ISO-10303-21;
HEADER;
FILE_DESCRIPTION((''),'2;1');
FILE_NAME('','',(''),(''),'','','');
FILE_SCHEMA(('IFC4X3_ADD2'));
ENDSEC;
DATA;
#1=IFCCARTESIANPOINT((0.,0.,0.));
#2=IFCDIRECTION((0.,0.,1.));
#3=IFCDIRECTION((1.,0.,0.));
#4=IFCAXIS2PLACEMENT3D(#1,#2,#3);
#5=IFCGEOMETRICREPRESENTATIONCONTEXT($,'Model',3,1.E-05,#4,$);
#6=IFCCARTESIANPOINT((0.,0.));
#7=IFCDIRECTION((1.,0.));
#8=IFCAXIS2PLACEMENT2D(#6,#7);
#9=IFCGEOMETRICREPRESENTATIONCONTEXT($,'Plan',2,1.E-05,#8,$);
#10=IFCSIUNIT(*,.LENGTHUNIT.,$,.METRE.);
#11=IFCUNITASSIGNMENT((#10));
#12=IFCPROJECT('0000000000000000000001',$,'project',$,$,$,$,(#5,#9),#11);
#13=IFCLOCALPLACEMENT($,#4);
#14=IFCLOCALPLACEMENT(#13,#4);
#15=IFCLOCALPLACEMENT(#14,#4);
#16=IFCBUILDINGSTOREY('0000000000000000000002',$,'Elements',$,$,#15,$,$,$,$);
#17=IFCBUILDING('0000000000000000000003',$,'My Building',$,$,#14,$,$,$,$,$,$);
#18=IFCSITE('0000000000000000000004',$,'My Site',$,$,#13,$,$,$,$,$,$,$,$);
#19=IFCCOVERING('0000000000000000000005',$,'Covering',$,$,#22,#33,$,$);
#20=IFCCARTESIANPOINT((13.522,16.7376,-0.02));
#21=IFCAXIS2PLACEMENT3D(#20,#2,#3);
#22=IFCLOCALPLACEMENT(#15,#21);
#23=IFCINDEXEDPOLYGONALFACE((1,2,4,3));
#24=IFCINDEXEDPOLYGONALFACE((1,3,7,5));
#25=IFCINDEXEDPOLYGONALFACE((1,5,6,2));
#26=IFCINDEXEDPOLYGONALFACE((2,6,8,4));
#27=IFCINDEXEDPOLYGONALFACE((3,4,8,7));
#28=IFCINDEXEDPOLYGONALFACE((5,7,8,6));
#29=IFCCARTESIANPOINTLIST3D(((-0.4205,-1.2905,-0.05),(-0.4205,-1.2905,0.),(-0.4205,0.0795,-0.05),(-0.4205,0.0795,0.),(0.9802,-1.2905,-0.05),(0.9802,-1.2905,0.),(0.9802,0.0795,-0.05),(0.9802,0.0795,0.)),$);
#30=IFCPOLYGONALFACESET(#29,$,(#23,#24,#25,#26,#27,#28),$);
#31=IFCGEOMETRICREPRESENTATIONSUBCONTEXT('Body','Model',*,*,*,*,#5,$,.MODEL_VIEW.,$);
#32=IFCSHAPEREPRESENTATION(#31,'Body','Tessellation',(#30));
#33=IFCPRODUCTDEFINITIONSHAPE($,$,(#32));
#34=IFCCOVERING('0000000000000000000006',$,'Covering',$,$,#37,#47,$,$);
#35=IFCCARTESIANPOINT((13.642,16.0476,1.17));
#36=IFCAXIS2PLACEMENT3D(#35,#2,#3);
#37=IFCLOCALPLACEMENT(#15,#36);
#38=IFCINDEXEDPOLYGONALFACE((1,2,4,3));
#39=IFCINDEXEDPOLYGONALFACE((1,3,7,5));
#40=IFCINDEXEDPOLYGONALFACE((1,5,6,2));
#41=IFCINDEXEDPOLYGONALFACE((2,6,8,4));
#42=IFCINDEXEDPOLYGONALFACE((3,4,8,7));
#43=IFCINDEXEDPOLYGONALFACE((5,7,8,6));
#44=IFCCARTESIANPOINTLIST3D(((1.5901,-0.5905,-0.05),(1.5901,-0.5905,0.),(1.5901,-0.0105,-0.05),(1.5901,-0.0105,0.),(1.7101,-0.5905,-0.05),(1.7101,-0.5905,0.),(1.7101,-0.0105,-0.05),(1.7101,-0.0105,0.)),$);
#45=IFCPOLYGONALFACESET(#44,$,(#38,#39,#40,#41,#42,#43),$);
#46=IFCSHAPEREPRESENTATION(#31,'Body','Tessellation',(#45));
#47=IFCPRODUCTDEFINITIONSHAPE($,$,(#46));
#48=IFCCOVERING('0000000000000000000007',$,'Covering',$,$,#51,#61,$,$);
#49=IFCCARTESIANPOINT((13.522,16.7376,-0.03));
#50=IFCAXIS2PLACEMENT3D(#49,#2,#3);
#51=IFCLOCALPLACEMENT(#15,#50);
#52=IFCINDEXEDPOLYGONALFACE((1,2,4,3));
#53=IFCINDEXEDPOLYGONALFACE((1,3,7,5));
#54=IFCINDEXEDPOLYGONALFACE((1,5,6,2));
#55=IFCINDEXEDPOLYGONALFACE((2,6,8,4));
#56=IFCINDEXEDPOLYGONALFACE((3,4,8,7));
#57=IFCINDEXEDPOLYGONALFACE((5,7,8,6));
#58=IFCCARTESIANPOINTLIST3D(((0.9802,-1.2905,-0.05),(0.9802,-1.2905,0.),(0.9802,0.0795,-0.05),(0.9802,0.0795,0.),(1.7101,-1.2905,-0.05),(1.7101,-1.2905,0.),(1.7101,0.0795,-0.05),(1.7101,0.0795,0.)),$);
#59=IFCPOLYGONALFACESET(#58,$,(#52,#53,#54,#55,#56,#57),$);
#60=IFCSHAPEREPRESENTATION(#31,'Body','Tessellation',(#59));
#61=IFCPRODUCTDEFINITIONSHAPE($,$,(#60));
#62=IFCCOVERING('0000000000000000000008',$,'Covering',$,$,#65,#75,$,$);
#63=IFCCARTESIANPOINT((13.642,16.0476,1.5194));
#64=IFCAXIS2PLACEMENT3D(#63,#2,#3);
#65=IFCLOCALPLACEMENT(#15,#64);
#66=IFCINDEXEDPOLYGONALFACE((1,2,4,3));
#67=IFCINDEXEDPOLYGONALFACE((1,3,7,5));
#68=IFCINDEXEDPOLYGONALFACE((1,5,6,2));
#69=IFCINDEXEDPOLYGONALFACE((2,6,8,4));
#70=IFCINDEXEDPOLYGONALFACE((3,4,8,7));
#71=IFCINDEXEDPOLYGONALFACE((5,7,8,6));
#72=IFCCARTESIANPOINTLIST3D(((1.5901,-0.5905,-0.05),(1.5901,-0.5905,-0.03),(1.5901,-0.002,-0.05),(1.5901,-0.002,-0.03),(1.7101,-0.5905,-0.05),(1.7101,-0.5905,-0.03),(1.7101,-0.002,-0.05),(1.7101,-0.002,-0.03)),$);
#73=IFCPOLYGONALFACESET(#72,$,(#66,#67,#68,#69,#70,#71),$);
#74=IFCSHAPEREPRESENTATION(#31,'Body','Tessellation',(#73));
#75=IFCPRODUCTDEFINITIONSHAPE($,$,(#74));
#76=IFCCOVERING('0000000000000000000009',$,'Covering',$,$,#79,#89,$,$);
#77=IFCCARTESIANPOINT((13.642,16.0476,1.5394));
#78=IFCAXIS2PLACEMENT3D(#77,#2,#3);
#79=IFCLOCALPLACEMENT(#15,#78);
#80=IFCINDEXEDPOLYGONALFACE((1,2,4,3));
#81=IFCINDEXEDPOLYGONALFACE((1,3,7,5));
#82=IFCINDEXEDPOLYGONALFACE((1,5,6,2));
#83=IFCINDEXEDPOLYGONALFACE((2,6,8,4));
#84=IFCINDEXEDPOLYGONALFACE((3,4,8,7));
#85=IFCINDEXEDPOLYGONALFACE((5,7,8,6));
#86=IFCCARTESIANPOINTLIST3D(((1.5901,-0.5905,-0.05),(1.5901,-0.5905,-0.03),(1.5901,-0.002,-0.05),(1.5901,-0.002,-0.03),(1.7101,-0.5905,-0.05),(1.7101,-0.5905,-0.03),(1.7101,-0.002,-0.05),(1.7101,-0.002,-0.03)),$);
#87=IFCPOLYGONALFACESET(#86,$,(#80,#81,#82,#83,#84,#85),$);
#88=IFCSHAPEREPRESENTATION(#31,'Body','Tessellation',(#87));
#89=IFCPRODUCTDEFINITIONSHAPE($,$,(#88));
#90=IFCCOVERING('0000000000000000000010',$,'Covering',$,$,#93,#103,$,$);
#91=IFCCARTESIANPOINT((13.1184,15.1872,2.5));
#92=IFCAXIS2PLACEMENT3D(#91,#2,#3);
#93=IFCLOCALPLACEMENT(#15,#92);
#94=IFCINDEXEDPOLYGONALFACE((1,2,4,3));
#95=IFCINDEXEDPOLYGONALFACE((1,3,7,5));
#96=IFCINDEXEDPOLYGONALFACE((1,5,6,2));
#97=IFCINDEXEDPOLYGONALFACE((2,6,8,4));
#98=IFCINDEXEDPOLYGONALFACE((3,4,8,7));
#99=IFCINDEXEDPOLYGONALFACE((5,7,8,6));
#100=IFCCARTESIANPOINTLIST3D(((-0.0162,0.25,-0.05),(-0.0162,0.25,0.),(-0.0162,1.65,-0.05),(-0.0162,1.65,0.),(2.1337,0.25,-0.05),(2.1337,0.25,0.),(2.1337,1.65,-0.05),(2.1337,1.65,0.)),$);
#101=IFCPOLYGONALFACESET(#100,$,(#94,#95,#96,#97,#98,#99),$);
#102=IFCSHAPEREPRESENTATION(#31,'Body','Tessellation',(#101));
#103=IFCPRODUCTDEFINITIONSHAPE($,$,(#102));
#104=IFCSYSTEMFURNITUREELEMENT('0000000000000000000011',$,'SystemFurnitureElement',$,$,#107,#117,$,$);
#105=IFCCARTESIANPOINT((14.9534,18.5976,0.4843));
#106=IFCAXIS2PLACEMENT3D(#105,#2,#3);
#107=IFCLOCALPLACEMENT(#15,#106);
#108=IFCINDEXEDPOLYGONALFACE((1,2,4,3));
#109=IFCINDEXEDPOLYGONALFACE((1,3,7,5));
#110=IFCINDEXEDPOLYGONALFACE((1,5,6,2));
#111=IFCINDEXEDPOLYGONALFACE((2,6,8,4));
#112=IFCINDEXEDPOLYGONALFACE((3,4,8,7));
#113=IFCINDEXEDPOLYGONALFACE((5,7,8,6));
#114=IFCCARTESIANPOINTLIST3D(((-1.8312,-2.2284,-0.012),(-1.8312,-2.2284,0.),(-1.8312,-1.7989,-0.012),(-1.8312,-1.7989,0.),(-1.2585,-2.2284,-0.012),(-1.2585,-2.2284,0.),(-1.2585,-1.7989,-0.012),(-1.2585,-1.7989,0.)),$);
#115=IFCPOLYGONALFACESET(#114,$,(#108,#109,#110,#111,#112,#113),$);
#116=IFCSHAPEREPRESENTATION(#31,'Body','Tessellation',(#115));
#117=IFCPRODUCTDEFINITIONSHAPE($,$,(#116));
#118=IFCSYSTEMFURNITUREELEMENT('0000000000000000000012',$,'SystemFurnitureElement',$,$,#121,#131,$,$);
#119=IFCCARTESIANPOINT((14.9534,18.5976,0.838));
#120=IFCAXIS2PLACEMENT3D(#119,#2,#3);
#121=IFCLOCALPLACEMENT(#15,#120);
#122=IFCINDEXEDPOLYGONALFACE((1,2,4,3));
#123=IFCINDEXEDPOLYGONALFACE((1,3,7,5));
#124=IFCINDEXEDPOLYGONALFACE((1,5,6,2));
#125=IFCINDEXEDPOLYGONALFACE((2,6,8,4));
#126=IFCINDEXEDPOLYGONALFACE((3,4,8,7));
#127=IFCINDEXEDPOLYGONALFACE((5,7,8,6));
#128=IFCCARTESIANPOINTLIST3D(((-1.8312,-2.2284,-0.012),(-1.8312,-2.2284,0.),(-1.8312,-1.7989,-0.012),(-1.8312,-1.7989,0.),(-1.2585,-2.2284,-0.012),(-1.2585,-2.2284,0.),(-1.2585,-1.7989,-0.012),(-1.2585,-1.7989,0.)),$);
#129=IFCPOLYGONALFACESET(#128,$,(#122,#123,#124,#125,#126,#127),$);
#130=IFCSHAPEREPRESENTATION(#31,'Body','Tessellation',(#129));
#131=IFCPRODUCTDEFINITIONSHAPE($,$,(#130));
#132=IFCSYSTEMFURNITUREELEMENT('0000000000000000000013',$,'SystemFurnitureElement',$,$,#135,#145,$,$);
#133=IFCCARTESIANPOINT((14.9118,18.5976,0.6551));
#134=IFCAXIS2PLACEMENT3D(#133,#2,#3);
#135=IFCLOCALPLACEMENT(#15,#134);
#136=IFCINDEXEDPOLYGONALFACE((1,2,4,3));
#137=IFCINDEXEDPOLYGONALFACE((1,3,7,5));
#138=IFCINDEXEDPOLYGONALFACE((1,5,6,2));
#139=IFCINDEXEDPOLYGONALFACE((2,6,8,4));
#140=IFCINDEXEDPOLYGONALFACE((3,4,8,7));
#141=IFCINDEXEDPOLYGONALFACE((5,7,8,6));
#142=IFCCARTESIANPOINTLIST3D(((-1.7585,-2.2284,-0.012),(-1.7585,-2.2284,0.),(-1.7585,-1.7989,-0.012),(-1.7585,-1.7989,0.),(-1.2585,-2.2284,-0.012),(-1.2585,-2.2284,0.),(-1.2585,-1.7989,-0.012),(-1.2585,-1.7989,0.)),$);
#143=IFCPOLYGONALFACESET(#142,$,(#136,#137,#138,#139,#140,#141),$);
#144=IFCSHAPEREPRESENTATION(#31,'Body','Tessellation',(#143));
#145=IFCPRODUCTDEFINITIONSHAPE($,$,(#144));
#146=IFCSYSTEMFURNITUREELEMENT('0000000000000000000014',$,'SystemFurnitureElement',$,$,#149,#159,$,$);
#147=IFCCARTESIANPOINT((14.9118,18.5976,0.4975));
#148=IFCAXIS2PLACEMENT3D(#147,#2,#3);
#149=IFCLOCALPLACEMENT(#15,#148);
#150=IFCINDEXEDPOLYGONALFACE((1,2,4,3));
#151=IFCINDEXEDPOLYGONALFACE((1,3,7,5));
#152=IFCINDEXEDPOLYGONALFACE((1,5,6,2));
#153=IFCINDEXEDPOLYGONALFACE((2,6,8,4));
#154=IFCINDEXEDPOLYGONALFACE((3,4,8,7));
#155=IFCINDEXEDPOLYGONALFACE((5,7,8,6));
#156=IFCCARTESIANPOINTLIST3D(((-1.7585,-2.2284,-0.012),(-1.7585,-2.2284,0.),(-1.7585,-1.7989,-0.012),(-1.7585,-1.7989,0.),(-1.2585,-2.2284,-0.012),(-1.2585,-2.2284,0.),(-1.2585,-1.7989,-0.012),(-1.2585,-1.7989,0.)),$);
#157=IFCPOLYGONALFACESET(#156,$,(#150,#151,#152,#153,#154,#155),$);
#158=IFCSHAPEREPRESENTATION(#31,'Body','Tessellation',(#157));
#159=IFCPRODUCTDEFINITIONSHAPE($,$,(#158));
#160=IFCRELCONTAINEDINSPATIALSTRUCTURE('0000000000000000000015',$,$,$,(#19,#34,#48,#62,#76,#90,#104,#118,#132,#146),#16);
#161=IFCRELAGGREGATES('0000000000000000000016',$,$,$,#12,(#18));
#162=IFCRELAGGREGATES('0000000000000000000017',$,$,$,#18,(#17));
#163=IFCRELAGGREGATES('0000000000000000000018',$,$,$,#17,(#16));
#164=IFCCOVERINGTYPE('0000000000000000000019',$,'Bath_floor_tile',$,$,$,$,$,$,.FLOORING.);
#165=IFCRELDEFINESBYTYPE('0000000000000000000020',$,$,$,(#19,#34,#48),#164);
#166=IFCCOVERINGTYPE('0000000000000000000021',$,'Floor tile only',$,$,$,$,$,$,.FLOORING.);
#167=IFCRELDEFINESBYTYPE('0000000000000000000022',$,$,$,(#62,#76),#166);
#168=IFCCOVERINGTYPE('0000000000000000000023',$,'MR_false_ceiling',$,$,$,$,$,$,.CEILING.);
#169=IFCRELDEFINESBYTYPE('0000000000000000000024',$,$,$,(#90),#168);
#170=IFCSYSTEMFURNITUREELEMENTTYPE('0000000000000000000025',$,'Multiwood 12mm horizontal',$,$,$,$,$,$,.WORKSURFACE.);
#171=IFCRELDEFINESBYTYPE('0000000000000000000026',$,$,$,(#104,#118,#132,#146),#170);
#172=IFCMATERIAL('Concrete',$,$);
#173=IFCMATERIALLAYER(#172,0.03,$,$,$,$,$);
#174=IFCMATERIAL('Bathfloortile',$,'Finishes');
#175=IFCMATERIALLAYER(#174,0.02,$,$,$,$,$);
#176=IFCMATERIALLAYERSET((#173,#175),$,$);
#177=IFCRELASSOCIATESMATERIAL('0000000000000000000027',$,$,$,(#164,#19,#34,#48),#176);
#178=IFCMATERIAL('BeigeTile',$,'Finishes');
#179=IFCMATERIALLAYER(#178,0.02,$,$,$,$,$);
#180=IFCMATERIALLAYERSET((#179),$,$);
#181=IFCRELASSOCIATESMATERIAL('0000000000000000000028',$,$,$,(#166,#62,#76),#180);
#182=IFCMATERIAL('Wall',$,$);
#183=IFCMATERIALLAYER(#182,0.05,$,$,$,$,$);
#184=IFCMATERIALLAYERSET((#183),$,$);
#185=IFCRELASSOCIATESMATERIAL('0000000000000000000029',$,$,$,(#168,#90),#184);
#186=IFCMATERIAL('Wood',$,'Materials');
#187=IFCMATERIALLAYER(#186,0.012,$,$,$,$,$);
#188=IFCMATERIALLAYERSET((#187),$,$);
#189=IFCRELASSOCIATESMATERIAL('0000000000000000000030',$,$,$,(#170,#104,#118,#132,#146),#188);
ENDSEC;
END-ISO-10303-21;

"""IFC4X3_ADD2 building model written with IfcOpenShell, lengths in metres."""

from ifc_helpers import new_model, si_unit, frame, origin_with_axes, origin_2d_with_axis, place, context, subcontext, project, spatial, indexed_curve, outline, extrude, material, layer, layer_set, layer_usage, type_object, element, save


model = new_model("IFC4X3_ADD2")

# Units and contexts
model_context = context("Model", 3, precision=1e-05, world=origin_with_axes())
plan_context = context("Plan", 2, precision=1e-05, world=origin_2d_with_axis())
body_context = subcontext(model_context, "Body", "Model", "MODEL_VIEW")
ifc_project = project(units=[si_unit("LENGTHUNIT", "METRE")], contexts=[model_context, plan_context])

# Site, building, storey
site_placement = place(None, origin_with_axes())
site = spatial("IfcSite", under=ifc_project, at=site_placement, Name="My Site")
building_placement = place(site_placement, origin_with_axes())
building = spatial("IfcBuilding", under=site, at=building_placement, Name="My Building")
storey_placement = place(building_placement, origin_with_axes())
storey = spatial("IfcBuildingStorey", under=building, at=storey_placement, Name="Elements")

# Shared definitions
ifc_material_1 = material(Name="Wall")

# Coverings
ifc_material_2 = material(Name="Concrete")
ifc_layer_1 = layer(ifc_material_2, 0.03)
ifc_material_3 = material(Name="Bathfloortile", Category="Finishes")
ifc_layer_2 = layer(ifc_material_3, 0.02)
ifc_layer_set_1 = layer_set([ifc_layer_1, ifc_layer_2])
ifc_layer_usage_1 = layer_usage(ifc_layer_set_1, "AXIS3", "POSITIVE", -0.05)
covering_type_1 = type_object("IfcCoveringType", Name="Bath_floor_tile", PredefinedType="FLOORING", material=ifc_layer_set_1)
covering_1_placement = place(storey_placement, frame((13.522, 16.7376, -0.02), z_axis=(0.0, 0.0, 1.0), x_axis=(1.0, 0.0, 0.0)))
element("IfcCovering", 1, at=covering_1_placement, inside=storey, type_object=covering_type_1, material=ifc_layer_usage_1, Name="Covering", context=body_context, shape_type="SweptSolid", body=[
    extrude(outline(indexed_curve([(-0.4205, -1.2905), (0.9802, -1.2905), (0.9802, 0.0795), (-0.4205, 0.0795), (-0.4205, -1.2905)])), frame((0.0, 0.0, -0.05), z_axis=(0.0, 0.0, 1.0), x_axis=(1.0, 0.0, 0.0)), (0.0, 0.0, 1.0), 0.05),
])
ifc_layer_usage_2 = layer_usage(ifc_layer_set_1, "AXIS3", "POSITIVE", -0.05)
covering_2_placement = place(storey_placement, frame((13.642, 16.0476, 1.17), z_axis=(0.0, 0.0, 1.0), x_axis=(1.0, 0.0, 0.0)))
element("IfcCovering", 2, at=covering_2_placement, inside=storey, type_object=covering_type_1, material=ifc_layer_usage_2, Name="Covering", context=body_context, shape_type="SweptSolid", body=[
    extrude(outline(indexed_curve([(1.7101, -0.0105), (1.7101, -0.5905), (1.5901, -0.5905), (1.5901, -0.0105), (1.7101, -0.0105)])), frame((0.0, 0.0, -0.05), z_axis=(0.0, 0.0, 1.0), x_axis=(1.0, 0.0, 0.0)), (0.0, 0.0, 1.0), 0.05),
])
ifc_layer_usage_3 = layer_usage(ifc_layer_set_1, "AXIS3", "POSITIVE", -0.05)
covering_3_placement = place(storey_placement, frame((13.522, 16.7376, -0.03), z_axis=(0.0, 0.0, 1.0), x_axis=(1.0, 0.0, 0.0)))
element("IfcCovering", 3, at=covering_3_placement, inside=storey, type_object=covering_type_1, material=ifc_layer_usage_3, Name="Covering", context=body_context, shape_type="SweptSolid", body=[
    extrude(outline(indexed_curve([(0.9802, 0.0795), (1.7101, 0.0795), (1.7101, -1.2905), (0.9802, -1.2905), (0.9802, 0.0795)])), frame((0.0, 0.0, -0.05), z_axis=(0.0, 0.0, 1.0), x_axis=(1.0, 0.0, 0.0)), (0.0, 0.0, 1.0), 0.05),
])
ifc_material_4 = material(Name="BeigeTile", Category="Finishes")
ifc_layer_3 = layer(ifc_material_4, 0.02)
ifc_layer_set_2 = layer_set([ifc_layer_3])
ifc_layer_usage_4 = layer_usage(ifc_layer_set_2, "AXIS3", "POSITIVE", -0.05)
covering_type_2 = type_object("IfcCoveringType", Name="Floor tile only", PredefinedType="FLOORING", material=ifc_layer_set_2)
covering_4_placement = place(storey_placement, frame((13.642, 16.0476, 1.5194), z_axis=(0.0, 0.0, 1.0), x_axis=(1.0, 0.0, 0.0)))
element("IfcCovering", 4, at=covering_4_placement, inside=storey, type_object=covering_type_2, material=ifc_layer_usage_4, Name="Covering", context=body_context, shape_type="SweptSolid", body=[
    extrude(outline(indexed_curve([(1.7101, -0.002), (1.7101, -0.5905), (1.5901, -0.5905), (1.5901, -0.002), (1.7101, -0.002)])), frame((0.0, 0.0, -0.05), z_axis=(0.0, 0.0, 1.0), x_axis=(1.0, 0.0, 0.0)), (0.0, 0.0, 1.0), 0.02),
])
ifc_layer_usage_5 = layer_usage(ifc_layer_set_2, "AXIS3", "POSITIVE", -0.05)
covering_5_placement = place(storey_placement, frame((13.642, 16.0476, 1.5394), z_axis=(0.0, 0.0, 1.0), x_axis=(1.0, 0.0, 0.0)))
element("IfcCovering", 5, at=covering_5_placement, inside=storey, type_object=covering_type_2, material=ifc_layer_usage_5, Name="Covering", context=body_context, shape_type="SweptSolid", body=[
    extrude(outline(indexed_curve([(1.7101, -0.002), (1.7101, -0.5905), (1.5901, -0.5905), (1.5901, -0.002), (1.7101, -0.002)])), frame((0.0, 0.0, -0.05), z_axis=(0.0, 0.0, 1.0), x_axis=(1.0, 0.0, 0.0)), (0.0, 0.0, 1.0), 0.02),
])
ifc_layer_4 = layer(ifc_material_1, 0.05)
ifc_layer_set_3 = layer_set([ifc_layer_4])
ifc_layer_usage_6 = layer_usage(ifc_layer_set_3, "AXIS3", "POSITIVE", -0.05)
covering_type_3 = type_object("IfcCoveringType", Name="MR_false_ceiling", PredefinedType="CEILING", material=ifc_layer_set_3)
covering_6_placement = place(storey_placement, frame((13.1184, 15.1872, 2.5), z_axis=(0.0, 0.0, 1.0), x_axis=(1.0, 0.0, 0.0)))
element("IfcCovering", 6, at=covering_6_placement, inside=storey, type_object=covering_type_3, material=ifc_layer_usage_6, Name="Covering", context=body_context, shape_type="SweptSolid", body=[
    extrude(outline(indexed_curve([(-0.0162, 1.65), (2.1337, 1.65), (2.1337, 0.25), (-0.0162, 0.25), (-0.0162, 1.65)])), frame((0.0, 0.0, -0.05), z_axis=(0.0, 0.0, 1.0), x_axis=(1.0, 0.0, 0.0)), (0.0, 0.0, 1.0), 0.05),
])

# System furniture elements
ifc_material_5 = material(Name="Wood", Category="Materials")
ifc_layer_5 = layer(ifc_material_5, 0.012)
ifc_layer_set_4 = layer_set([ifc_layer_5])
ifc_layer_usage_7 = layer_usage(ifc_layer_set_4, "AXIS3", "POSITIVE", -0.012)
system_furniture_element_type_1 = type_object("IfcSystemFurnitureElementType", Name="Multiwood 12mm horizontal", PredefinedType="WORKSURFACE", material=ifc_layer_set_4)
system_furniture_element_1_placement = place(storey_placement, frame((14.9534, 18.5976, 0.4843), z_axis=(0.0, 0.0, 1.0), x_axis=(1.0, 0.0, 0.0)))
element("IfcSystemFurnitureElement", 7, at=system_furniture_element_1_placement, inside=storey, type_object=system_furniture_element_type_1, material=ifc_layer_usage_7, Name="SystemFurnitureElement", context=body_context, shape_type="SweptSolid", body=[
    extrude(outline(indexed_curve([(-1.2585, -1.7989), (-1.2585, -2.2284), (-1.8312, -2.2284), (-1.8312, -1.7989), (-1.2585, -1.7989)])), frame((0.0, 0.0, -0.012), z_axis=(0.0, 0.0, 1.0), x_axis=(1.0, 0.0, 0.0)), (0.0, 0.0, 1.0), 0.012),
])
ifc_layer_usage_8 = layer_usage(ifc_layer_set_4, "AXIS3", "POSITIVE", -0.012)
system_furniture_element_2_placement = place(storey_placement, frame((14.9534, 18.5976, 0.838), z_axis=(0.0, 0.0, 1.0), x_axis=(1.0, 0.0, 0.0)))
element("IfcSystemFurnitureElement", 8, at=system_furniture_element_2_placement, inside=storey, type_object=system_furniture_element_type_1, material=ifc_layer_usage_8, Name="SystemFurnitureElement", context=body_context, shape_type="SweptSolid", body=[
    extrude(outline(indexed_curve([(-1.2585, -1.7989), (-1.2585, -2.2284), (-1.8312, -2.2284), (-1.8312, -1.7989), (-1.2585, -1.7989)])), frame((0.0, 0.0, -0.012), z_axis=(0.0, 0.0, 1.0), x_axis=(1.0, 0.0, 0.0)), (0.0, 0.0, 1.0), 0.012),
])
ifc_layer_usage_9 = layer_usage(ifc_layer_set_4, "AXIS3", "POSITIVE", -0.012)
system_furniture_element_3_placement = place(storey_placement, frame((14.9118, 18.5976, 0.6551), z_axis=(0.0, 0.0, 1.0), x_axis=(1.0, 0.0, 0.0)))
element("IfcSystemFurnitureElement", 9, at=system_furniture_element_3_placement, inside=storey, type_object=system_furniture_element_type_1, material=ifc_layer_usage_9, Name="SystemFurnitureElement", context=body_context, shape_type="SweptSolid", body=[
    extrude(outline(indexed_curve([(-1.7585, -1.7989), (-1.7585, -2.2284), (-1.2585, -2.2284), (-1.2585, -1.7989), (-1.7585, -1.7989)])), frame((0.0, 0.0, -0.012), z_axis=(0.0, 0.0, 1.0), x_axis=(1.0, 0.0, 0.0)), (0.0, 0.0, 1.0), 0.012),
])
ifc_layer_usage_10 = layer_usage(ifc_layer_set_4, "AXIS3", "POSITIVE", -0.012)
system_furniture_element_4_placement = place(storey_placement, frame((14.9118, 18.5976, 0.4975), z_axis=(0.0, 0.0, 1.0), x_axis=(1.0, 0.0, 0.0)))
element("IfcSystemFurnitureElement", 10, at=system_furniture_element_4_placement, inside=storey, type_object=system_furniture_element_type_1, material=ifc_layer_usage_10, Name="SystemFurnitureElement", context=body_context, shape_type="SweptSolid", body=[
    extrude(outline(indexed_curve([(-1.7585, -1.7989), (-1.7585, -2.2284), (-1.2585, -2.2284), (-1.2585, -1.7989), (-1.7585, -1.7989)])), frame((0.0, 0.0, -0.012), z_axis=(0.0, 0.0, 1.0), x_axis=(1.0, 0.0, 0.0)), (0.0, 0.0, 1.0), 0.012),
])

save(model, "model.ifc")
